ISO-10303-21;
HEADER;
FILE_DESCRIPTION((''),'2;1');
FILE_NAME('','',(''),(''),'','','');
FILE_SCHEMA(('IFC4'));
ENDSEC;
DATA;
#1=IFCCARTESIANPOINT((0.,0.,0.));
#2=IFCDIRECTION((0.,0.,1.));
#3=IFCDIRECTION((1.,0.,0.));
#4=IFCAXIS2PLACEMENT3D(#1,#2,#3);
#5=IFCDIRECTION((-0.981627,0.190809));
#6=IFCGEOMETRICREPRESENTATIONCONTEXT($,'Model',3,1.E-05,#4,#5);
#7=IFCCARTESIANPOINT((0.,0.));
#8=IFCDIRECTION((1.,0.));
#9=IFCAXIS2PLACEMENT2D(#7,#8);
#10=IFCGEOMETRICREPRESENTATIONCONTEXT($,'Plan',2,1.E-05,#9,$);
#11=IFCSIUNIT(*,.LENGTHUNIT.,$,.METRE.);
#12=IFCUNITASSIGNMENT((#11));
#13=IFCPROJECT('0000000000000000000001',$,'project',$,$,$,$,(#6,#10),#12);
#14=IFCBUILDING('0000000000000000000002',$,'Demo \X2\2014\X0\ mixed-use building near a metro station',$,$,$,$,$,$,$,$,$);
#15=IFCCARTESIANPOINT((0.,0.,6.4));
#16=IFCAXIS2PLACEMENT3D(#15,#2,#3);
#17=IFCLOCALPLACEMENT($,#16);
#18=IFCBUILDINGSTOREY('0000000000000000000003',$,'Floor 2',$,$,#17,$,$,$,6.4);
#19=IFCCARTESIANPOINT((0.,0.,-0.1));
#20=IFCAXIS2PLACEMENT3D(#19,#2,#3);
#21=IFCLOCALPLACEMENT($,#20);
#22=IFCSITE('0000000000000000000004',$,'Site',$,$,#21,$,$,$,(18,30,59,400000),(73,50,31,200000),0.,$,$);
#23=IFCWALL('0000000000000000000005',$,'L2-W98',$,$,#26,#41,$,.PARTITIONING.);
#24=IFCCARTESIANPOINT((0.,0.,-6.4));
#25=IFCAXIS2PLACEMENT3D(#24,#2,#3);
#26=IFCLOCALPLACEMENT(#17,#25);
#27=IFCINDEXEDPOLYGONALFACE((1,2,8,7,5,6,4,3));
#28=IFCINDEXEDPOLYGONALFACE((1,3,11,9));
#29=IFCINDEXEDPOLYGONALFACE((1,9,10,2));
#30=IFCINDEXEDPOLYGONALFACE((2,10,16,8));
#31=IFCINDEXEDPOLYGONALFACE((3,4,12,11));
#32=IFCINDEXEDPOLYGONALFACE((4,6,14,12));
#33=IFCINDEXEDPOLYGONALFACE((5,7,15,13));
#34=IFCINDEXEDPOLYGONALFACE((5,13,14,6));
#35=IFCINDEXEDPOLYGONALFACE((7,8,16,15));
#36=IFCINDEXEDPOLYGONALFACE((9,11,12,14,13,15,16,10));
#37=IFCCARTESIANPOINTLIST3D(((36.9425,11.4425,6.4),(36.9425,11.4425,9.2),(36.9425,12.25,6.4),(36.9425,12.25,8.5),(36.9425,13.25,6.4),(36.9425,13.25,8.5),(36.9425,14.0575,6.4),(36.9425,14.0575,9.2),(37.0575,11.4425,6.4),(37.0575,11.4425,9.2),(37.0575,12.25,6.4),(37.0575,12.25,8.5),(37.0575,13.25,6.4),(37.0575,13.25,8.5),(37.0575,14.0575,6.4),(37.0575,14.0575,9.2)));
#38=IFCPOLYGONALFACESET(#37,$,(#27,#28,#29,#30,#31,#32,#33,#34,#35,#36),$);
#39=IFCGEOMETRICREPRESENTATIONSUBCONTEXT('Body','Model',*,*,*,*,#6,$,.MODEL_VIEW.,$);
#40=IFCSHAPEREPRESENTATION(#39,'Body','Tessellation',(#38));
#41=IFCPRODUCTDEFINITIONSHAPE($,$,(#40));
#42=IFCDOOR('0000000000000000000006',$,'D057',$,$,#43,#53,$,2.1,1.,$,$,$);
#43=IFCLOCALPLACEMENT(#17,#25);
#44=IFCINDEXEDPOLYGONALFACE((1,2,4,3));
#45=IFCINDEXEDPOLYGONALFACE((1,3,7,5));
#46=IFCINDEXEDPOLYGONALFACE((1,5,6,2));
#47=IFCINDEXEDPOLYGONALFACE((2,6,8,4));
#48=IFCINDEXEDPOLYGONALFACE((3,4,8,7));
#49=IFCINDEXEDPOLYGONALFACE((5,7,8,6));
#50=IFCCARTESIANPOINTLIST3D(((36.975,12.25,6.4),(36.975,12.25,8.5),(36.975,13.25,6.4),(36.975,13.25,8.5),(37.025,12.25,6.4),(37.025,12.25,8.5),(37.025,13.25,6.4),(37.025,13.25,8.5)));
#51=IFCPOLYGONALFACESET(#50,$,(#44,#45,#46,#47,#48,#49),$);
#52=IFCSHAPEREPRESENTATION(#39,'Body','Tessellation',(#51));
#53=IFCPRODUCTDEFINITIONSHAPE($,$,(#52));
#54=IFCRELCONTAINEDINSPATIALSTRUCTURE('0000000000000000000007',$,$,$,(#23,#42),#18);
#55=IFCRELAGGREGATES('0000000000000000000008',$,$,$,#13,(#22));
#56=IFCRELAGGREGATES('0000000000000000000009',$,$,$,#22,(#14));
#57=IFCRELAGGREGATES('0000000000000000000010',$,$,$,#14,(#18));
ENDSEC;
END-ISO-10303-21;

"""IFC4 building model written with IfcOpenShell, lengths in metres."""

from ifc_helpers import new_model, si_unit, direction, frame, origin_with_axes, origin_2d_with_axis, place, context, subcontext, project, spatial, line, indexed_curve, outline, extrude, element, fill, save


model = new_model("IFC4")

# Units and contexts
model_context = context("Model", 3, precision=1e-05, world=origin_with_axes(), true_north=direction((-0.981627, 0.190809)))
plan_context = context("Plan", 2, precision=1e-05, world=origin_2d_with_axis())
body_context = subcontext(model_context, "Body", "Model", "MODEL_VIEW")
ifc_project = project(units=[si_unit("LENGTHUNIT", "METRE")], contexts=[model_context, plan_context])

# Site, building, storey
site_placement = place(None, frame((0.0, 0.0, -0.1), z_axis=(0.0, 0.0, 1.0), x_axis=(1.0, 0.0, 0.0)))
site = spatial("IfcSite", under=ifc_project, at=site_placement, Name="Site", RefLatitude=(18, 30, 59, 400000), RefLongitude=(73, 50, 31, 200000), RefElevation=0.0)
building = spatial("IfcBuilding", under=site, Name="Demo — mixed-use building near a metro station")
storey_placement = place(None, frame((0.0, 0.0, 6.4), z_axis=(0.0, 0.0, 1.0), x_axis=(1.0, 0.0, 0.0)))
storey = spatial("IfcBuildingStorey", under=building, at=storey_placement, Name="Floor 2", Elevation=6.4)

# Wall, opening, door
wall_1_placement = place(storey_placement, frame((0.0, 0.0, -6.4), z_axis=(0.0, 0.0, 1.0), x_axis=(1.0, 0.0, 0.0)))
wall_1 = element("IfcWall", 1, at=wall_1_placement, inside=storey, Name="L2-W98", PredefinedType="PARTITIONING", context=body_context, shape_type="SweptSolid", body=[
    extrude(outline(indexed_curve([(36.9425, 11.4425), (36.9425, 14.0575), (37.0575, 14.0575), (37.0575, 11.4425)], segments=[line(1, 2, 3, 4, 1)])), frame((0.0, 0.0, 6.4), z_axis=(0.0, 0.0, 1.0), x_axis=(1.0, 0.0, 0.0)), (0.0, 0.0, 1.0), 2.8),
])
opening_1_placement = place(wall_1_placement, origin_with_axes())
opening_1 = element("IfcOpeningElement", 2, at=opening_1_placement, cuts=wall_1, context=body_context, shape_type="SweptSolid", body=[
    extrude(outline(indexed_curve([(36.8925, 12.25), (36.8925, 13.25), (37.1075, 13.25), (37.1075, 12.25)], segments=[line(1, 2, 3, 4, 1)])), frame((0.0, 0.0, 6.4), z_axis=(0.0, 0.0, 1.0), x_axis=(1.0, 0.0, 0.0)), (0.0, 0.0, 1.0), 2.1),
])
door_1_placement = place(storey_placement, frame((0.0, 0.0, -6.4), z_axis=(0.0, 0.0, 1.0), x_axis=(1.0, 0.0, 0.0)))
door_1 = element("IfcDoor", 3, at=door_1_placement, inside=storey, Name="D057", OverallHeight=2.1, OverallWidth=1.0, context=body_context, shape_type="SweptSolid", body=[
    extrude(outline(indexed_curve([(36.975, 12.25), (36.975, 13.25), (37.025, 13.25), (37.025, 12.25)], segments=[line(1, 2, 3, 4, 1)])), frame((0.0, 0.0, 6.4), z_axis=(0.0, 0.0, 1.0), x_axis=(1.0, 0.0, 0.0)), (0.0, 0.0, 1.0), 2.1),
])
fill(opening_1, door_1)

save(model, "model.ifc")
